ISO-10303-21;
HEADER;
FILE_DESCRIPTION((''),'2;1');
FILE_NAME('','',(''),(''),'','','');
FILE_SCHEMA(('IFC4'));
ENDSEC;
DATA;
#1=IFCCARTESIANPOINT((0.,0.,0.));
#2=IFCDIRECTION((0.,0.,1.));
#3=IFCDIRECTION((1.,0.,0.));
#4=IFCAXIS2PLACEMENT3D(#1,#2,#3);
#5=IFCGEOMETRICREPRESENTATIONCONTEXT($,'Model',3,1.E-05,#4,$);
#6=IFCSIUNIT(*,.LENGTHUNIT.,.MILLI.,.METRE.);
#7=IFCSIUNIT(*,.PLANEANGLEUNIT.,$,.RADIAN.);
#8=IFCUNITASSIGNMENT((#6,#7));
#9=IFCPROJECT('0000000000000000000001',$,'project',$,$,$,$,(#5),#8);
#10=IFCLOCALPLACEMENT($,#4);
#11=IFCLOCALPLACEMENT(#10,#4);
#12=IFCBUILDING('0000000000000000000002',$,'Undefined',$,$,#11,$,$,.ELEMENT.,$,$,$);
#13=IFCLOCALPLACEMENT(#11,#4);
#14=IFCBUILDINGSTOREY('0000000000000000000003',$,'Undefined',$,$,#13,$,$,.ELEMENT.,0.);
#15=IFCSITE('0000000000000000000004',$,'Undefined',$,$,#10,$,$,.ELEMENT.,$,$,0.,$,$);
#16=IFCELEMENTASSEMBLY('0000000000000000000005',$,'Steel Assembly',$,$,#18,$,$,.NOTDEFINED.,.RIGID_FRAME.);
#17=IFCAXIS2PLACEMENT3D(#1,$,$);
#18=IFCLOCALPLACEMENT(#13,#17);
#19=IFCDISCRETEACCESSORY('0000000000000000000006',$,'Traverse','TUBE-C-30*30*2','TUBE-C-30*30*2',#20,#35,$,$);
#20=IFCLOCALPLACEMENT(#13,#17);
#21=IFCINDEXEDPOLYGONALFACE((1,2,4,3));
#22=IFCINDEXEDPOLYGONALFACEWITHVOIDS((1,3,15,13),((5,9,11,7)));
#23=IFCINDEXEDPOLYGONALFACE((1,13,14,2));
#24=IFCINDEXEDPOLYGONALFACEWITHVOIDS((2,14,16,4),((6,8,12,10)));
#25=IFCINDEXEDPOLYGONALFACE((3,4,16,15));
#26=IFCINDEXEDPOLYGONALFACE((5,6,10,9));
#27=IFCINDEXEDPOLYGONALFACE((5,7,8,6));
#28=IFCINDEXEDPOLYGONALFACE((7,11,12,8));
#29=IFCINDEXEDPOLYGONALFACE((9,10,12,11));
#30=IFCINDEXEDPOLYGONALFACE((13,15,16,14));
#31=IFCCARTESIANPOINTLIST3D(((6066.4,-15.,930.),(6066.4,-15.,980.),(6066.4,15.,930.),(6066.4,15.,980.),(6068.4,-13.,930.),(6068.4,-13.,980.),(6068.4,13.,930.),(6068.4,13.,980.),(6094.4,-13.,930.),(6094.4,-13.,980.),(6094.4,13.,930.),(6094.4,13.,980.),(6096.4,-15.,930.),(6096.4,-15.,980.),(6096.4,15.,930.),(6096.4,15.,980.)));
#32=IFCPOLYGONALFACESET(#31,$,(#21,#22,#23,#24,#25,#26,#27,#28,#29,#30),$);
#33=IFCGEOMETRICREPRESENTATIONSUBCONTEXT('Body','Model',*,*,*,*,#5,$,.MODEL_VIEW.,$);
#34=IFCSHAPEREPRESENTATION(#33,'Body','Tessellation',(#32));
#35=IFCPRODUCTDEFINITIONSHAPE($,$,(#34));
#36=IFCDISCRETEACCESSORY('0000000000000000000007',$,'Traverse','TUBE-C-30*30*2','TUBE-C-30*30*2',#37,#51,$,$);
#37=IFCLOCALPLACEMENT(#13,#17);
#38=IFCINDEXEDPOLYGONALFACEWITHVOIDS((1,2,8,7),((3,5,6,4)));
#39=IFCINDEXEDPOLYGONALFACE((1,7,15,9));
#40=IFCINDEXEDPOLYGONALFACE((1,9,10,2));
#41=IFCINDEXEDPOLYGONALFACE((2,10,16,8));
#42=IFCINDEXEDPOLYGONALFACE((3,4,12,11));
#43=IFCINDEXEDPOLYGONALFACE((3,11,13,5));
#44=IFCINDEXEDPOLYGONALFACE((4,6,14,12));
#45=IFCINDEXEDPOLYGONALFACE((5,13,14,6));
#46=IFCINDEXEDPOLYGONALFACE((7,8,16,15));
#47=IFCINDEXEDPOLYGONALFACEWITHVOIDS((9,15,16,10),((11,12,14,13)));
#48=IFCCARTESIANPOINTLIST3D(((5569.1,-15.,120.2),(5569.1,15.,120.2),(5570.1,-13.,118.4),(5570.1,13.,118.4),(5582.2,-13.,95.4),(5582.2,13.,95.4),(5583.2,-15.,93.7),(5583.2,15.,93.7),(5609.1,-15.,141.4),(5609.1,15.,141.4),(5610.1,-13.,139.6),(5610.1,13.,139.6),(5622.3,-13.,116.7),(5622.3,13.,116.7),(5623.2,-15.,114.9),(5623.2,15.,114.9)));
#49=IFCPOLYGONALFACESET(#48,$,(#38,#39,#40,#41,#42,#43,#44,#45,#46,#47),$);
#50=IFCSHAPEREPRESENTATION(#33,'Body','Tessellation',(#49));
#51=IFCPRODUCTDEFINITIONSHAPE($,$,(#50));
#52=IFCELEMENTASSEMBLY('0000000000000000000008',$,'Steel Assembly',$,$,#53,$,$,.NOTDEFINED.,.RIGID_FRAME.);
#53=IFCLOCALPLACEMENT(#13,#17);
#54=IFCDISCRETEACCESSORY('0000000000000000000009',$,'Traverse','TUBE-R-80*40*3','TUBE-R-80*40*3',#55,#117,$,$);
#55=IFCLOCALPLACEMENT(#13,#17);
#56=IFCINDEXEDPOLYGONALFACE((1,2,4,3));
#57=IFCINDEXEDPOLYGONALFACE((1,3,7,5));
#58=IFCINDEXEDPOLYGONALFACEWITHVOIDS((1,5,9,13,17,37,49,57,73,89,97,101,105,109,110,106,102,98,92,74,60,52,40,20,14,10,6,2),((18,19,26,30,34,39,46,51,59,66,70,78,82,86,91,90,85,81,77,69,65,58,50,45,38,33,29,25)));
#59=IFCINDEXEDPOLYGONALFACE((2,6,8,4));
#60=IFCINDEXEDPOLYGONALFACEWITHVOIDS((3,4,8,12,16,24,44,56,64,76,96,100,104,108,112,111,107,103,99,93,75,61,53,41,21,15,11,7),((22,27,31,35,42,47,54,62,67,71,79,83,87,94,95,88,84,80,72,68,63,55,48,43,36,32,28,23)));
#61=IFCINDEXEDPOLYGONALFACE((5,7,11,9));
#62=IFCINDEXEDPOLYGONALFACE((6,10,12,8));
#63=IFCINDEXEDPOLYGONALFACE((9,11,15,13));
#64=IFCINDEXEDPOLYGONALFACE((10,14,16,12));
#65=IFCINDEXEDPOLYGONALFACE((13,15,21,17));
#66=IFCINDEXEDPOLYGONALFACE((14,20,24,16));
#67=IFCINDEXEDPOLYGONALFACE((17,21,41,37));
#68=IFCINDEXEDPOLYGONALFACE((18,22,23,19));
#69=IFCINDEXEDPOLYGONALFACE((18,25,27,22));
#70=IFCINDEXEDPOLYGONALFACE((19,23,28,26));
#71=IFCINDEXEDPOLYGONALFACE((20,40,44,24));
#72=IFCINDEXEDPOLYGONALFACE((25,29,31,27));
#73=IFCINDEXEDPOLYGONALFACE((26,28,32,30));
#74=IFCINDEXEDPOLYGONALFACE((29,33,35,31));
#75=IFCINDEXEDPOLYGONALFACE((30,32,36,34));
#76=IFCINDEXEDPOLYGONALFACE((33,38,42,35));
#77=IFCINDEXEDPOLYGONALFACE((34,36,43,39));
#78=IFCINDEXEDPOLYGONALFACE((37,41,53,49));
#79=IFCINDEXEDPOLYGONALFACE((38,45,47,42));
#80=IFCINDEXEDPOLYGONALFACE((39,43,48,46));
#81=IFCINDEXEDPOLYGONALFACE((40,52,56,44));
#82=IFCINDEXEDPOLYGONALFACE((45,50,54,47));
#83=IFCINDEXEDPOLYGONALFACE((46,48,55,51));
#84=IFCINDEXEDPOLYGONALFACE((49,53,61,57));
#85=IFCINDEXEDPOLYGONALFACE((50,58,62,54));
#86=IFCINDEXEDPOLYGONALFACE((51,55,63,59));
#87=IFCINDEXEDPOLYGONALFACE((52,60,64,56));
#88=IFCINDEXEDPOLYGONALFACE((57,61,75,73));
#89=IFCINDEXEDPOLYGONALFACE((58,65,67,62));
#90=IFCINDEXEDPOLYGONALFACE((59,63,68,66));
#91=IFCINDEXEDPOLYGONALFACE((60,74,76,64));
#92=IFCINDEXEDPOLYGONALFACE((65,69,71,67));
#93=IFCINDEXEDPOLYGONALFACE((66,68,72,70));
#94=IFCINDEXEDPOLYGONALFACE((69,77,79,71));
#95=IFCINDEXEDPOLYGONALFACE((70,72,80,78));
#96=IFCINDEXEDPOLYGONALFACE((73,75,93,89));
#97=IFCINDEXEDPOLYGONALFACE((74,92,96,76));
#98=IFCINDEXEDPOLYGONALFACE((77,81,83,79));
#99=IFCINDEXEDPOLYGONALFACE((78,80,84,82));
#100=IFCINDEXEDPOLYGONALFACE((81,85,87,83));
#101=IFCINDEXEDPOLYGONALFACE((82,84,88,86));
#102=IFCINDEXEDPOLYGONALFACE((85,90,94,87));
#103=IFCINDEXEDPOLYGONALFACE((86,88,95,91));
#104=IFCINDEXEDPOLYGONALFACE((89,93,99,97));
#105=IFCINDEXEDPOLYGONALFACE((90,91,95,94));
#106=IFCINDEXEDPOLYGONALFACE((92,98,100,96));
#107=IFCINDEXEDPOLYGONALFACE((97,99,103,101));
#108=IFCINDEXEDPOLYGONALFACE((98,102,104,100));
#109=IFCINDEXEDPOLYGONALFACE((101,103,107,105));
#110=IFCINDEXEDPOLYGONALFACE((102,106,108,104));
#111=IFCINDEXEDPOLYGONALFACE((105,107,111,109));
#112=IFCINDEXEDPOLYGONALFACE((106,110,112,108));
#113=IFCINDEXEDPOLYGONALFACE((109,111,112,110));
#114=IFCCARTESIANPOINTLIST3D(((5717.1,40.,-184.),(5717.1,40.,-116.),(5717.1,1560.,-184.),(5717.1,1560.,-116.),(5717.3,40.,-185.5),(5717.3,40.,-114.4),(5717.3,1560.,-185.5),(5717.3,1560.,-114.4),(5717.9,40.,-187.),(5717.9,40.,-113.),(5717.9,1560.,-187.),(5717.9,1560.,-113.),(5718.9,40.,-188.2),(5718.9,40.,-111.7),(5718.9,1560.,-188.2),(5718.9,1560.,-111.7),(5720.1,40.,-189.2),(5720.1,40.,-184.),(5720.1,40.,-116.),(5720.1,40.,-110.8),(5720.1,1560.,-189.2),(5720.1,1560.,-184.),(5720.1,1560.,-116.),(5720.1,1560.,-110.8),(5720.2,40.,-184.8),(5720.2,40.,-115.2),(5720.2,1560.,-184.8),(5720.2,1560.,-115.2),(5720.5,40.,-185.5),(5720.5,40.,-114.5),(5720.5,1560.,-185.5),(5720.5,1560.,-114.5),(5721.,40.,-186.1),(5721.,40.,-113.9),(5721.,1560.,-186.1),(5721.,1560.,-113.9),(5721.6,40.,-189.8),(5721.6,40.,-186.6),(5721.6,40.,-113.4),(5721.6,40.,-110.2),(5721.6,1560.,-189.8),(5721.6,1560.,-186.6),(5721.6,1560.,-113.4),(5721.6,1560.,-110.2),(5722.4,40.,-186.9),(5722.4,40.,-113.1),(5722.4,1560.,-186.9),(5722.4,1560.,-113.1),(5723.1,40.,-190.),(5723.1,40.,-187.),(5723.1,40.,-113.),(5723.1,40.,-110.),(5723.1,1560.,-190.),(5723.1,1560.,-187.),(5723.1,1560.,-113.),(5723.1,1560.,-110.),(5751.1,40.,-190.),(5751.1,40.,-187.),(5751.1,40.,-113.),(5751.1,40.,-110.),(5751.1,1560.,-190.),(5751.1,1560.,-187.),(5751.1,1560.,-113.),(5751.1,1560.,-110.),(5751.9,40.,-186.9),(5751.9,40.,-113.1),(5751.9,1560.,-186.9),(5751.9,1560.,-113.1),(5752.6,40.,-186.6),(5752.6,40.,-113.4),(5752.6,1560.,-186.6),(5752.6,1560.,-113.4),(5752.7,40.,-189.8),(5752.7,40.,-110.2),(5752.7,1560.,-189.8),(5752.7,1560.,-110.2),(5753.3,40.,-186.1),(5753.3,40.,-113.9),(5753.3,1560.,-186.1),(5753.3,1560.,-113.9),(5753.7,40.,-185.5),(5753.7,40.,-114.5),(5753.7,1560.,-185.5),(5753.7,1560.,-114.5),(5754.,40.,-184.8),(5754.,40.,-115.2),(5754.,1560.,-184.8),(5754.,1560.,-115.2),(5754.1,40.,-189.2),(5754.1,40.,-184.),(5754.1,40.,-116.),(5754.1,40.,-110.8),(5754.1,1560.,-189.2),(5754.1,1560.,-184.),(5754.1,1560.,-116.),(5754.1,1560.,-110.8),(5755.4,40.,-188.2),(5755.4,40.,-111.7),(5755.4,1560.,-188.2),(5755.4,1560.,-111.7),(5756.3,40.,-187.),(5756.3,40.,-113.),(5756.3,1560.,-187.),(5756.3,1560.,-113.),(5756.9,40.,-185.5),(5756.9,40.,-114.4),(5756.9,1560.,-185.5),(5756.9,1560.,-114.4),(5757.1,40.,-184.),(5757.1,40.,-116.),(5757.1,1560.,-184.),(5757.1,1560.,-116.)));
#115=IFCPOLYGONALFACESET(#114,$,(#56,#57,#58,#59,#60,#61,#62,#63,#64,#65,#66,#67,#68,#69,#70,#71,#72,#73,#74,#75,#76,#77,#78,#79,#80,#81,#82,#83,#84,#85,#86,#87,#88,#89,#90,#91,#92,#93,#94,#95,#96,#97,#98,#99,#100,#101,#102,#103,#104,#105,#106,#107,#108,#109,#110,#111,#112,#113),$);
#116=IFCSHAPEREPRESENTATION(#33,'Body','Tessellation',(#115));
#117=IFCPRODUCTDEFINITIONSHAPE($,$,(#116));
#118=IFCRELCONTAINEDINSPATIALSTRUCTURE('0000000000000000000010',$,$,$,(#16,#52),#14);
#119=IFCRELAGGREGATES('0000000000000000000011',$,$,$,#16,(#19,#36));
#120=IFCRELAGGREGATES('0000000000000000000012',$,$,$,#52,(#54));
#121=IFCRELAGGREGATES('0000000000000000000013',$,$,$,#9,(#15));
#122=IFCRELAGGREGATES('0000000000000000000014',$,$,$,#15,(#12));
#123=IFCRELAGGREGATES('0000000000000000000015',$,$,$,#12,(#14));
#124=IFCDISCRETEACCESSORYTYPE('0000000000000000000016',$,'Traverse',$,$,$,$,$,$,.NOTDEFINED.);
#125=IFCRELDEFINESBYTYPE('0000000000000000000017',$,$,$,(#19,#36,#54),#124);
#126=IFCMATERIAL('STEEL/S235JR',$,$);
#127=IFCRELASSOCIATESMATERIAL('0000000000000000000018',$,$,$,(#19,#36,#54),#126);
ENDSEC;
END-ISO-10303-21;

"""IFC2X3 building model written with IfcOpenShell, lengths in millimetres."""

from ifc_helpers import new_model, si_unit, frame, origin_with_axes, origin_2d_with_axis, place, context, subcontext, project, spatial, hollow_rectangle, extrude, material, type_object, element, aggregate, save


model = new_model("IFC2X3")

# Units and contexts
model_context = context("Model", 3, precision=1e-05, world=origin_with_axes())
body_context = subcontext(model_context, "Body", "Model", "MODEL_VIEW")
ifc_project = project(units=[si_unit("LENGTHUNIT", "METRE", prefix="MILLI"), si_unit("PLANEANGLEUNIT", "RADIAN")], contexts=[model_context])

# Site, building, storey
site_placement = place(None, origin_with_axes())
site = spatial("IfcSite", under=ifc_project, at=site_placement, Name="Undefined", CompositionType="ELEMENT", RefElevation=0.0)
building_placement = place(site_placement, origin_with_axes())
building = spatial("IfcBuilding", under=site, at=building_placement, Name="Undefined", CompositionType="ELEMENT")
storey_placement = place(building_placement, origin_with_axes())
storey = spatial("IfcBuildingStorey", under=building, at=storey_placement, Name="Undefined", CompositionType="ELEMENT", Elevation=0.0)

# Element assembly
ifc_material = material(Name="STEEL/S235JR")
assembly_1_placement = place(storey_placement, origin_with_axes())
assembly_1 = element("IfcElementAssembly", 1, at=assembly_1_placement, inside=storey, Name="Steel Assembly", AssemblyPlace="NOTDEFINED", PredefinedType="RIGID_FRAME")

# Discrete accessories
discrete_accessory_type_1 = type_object("IfcDiscreteAccessoryType", Name="Traverse")
discrete_accessory_1_placement = place(assembly_1_placement, frame((6081.4, 0.0, 930.0), z_axis=(0.0, 0.0, 1.0), x_axis=(1.0, 0.0, 0.0)))
discrete_accessory_1 = element("IfcDiscreteAccessory", 2, at=discrete_accessory_1_placement, type_object=discrete_accessory_type_1, material=ifc_material, Name="Traverse", Description="TUBE-C-30*30*2", ObjectType="TUBE-C-30*30*2", context=body_context, shape_type="SweptSolid", body=[
    extrude(hollow_rectangle(XDim=30.0, YDim=30.0, WallThickness=2.0, at=origin_2d_with_axis()), frame((0.0, 0.0, 50.0), z_axis=(0.0, 0.0, -1.0), x_axis=(-1.0, 0.0, 0.0)), (0.0, 0.0, 1.0), 50.0),
])
discrete_accessory_2_placement = place(assembly_1_placement, frame((5616.2, 0.0, 128.2), z_axis=(0.0, 1.0, 0.0), x_axis=(-0.883506, 0.0, -0.46842)))
discrete_accessory_2 = element("IfcDiscreteAccessory", 3, at=discrete_accessory_2_placement, type_object=discrete_accessory_type_1, material=ifc_material, Name="Traverse", Description="TUBE-C-30*30*2", ObjectType="TUBE-C-30*30*2", context=body_context, shape_type="SweptSolid", body=[
    extrude(hollow_rectangle(XDim=30.0, YDim=30.0, WallThickness=2.0, at=origin_2d_with_axis()), frame((45.3, 0.0, 0.0), z_axis=(-1.0, 0.0, 0.0), x_axis=(0.0, -1.0, 0.0)), (0.0, 0.0, 1.0), 45.3),
])
aggregate(assembly_1, [discrete_accessory_1, discrete_accessory_2])

# Element assembly, discrete accessory
assembly_2_placement = place(storey_placement, origin_with_axes())
assembly_2 = element("IfcElementAssembly", 4, at=assembly_2_placement, inside=storey, Name="Steel Assembly", AssemblyPlace="NOTDEFINED", PredefinedType="RIGID_FRAME")
discrete_accessory_3_placement = place(assembly_2_placement, frame((5737.1, 1560.0, -150.0), z_axis=(0.0, 0.0, 1.0), x_axis=(0.0, -1.0, 0.0)))
discrete_accessory_3 = element("IfcDiscreteAccessory", 5, at=discrete_accessory_3_placement, type_object=discrete_accessory_type_1, material=ifc_material, Name="Traverse", Description="TUBE-R-80*40*3", ObjectType="TUBE-R-80*40*3", context=body_context, shape_type="SweptSolid", body=[
    extrude(hollow_rectangle(XDim=40.0, YDim=80.0, WallThickness=3.0, InnerFilletRadius=3.0, OuterFilletRadius=6.0, at=origin_2d_with_axis()), frame((1520.0, 0.0, 0.0), z_axis=(-1.0, 0.0, 0.0), x_axis=(0.0, -1.0, 0.0)), (0.0, 0.0, 1.0), 1520.0),
])
aggregate(assembly_2, [discrete_accessory_3])

save(model, "model.ifc")
